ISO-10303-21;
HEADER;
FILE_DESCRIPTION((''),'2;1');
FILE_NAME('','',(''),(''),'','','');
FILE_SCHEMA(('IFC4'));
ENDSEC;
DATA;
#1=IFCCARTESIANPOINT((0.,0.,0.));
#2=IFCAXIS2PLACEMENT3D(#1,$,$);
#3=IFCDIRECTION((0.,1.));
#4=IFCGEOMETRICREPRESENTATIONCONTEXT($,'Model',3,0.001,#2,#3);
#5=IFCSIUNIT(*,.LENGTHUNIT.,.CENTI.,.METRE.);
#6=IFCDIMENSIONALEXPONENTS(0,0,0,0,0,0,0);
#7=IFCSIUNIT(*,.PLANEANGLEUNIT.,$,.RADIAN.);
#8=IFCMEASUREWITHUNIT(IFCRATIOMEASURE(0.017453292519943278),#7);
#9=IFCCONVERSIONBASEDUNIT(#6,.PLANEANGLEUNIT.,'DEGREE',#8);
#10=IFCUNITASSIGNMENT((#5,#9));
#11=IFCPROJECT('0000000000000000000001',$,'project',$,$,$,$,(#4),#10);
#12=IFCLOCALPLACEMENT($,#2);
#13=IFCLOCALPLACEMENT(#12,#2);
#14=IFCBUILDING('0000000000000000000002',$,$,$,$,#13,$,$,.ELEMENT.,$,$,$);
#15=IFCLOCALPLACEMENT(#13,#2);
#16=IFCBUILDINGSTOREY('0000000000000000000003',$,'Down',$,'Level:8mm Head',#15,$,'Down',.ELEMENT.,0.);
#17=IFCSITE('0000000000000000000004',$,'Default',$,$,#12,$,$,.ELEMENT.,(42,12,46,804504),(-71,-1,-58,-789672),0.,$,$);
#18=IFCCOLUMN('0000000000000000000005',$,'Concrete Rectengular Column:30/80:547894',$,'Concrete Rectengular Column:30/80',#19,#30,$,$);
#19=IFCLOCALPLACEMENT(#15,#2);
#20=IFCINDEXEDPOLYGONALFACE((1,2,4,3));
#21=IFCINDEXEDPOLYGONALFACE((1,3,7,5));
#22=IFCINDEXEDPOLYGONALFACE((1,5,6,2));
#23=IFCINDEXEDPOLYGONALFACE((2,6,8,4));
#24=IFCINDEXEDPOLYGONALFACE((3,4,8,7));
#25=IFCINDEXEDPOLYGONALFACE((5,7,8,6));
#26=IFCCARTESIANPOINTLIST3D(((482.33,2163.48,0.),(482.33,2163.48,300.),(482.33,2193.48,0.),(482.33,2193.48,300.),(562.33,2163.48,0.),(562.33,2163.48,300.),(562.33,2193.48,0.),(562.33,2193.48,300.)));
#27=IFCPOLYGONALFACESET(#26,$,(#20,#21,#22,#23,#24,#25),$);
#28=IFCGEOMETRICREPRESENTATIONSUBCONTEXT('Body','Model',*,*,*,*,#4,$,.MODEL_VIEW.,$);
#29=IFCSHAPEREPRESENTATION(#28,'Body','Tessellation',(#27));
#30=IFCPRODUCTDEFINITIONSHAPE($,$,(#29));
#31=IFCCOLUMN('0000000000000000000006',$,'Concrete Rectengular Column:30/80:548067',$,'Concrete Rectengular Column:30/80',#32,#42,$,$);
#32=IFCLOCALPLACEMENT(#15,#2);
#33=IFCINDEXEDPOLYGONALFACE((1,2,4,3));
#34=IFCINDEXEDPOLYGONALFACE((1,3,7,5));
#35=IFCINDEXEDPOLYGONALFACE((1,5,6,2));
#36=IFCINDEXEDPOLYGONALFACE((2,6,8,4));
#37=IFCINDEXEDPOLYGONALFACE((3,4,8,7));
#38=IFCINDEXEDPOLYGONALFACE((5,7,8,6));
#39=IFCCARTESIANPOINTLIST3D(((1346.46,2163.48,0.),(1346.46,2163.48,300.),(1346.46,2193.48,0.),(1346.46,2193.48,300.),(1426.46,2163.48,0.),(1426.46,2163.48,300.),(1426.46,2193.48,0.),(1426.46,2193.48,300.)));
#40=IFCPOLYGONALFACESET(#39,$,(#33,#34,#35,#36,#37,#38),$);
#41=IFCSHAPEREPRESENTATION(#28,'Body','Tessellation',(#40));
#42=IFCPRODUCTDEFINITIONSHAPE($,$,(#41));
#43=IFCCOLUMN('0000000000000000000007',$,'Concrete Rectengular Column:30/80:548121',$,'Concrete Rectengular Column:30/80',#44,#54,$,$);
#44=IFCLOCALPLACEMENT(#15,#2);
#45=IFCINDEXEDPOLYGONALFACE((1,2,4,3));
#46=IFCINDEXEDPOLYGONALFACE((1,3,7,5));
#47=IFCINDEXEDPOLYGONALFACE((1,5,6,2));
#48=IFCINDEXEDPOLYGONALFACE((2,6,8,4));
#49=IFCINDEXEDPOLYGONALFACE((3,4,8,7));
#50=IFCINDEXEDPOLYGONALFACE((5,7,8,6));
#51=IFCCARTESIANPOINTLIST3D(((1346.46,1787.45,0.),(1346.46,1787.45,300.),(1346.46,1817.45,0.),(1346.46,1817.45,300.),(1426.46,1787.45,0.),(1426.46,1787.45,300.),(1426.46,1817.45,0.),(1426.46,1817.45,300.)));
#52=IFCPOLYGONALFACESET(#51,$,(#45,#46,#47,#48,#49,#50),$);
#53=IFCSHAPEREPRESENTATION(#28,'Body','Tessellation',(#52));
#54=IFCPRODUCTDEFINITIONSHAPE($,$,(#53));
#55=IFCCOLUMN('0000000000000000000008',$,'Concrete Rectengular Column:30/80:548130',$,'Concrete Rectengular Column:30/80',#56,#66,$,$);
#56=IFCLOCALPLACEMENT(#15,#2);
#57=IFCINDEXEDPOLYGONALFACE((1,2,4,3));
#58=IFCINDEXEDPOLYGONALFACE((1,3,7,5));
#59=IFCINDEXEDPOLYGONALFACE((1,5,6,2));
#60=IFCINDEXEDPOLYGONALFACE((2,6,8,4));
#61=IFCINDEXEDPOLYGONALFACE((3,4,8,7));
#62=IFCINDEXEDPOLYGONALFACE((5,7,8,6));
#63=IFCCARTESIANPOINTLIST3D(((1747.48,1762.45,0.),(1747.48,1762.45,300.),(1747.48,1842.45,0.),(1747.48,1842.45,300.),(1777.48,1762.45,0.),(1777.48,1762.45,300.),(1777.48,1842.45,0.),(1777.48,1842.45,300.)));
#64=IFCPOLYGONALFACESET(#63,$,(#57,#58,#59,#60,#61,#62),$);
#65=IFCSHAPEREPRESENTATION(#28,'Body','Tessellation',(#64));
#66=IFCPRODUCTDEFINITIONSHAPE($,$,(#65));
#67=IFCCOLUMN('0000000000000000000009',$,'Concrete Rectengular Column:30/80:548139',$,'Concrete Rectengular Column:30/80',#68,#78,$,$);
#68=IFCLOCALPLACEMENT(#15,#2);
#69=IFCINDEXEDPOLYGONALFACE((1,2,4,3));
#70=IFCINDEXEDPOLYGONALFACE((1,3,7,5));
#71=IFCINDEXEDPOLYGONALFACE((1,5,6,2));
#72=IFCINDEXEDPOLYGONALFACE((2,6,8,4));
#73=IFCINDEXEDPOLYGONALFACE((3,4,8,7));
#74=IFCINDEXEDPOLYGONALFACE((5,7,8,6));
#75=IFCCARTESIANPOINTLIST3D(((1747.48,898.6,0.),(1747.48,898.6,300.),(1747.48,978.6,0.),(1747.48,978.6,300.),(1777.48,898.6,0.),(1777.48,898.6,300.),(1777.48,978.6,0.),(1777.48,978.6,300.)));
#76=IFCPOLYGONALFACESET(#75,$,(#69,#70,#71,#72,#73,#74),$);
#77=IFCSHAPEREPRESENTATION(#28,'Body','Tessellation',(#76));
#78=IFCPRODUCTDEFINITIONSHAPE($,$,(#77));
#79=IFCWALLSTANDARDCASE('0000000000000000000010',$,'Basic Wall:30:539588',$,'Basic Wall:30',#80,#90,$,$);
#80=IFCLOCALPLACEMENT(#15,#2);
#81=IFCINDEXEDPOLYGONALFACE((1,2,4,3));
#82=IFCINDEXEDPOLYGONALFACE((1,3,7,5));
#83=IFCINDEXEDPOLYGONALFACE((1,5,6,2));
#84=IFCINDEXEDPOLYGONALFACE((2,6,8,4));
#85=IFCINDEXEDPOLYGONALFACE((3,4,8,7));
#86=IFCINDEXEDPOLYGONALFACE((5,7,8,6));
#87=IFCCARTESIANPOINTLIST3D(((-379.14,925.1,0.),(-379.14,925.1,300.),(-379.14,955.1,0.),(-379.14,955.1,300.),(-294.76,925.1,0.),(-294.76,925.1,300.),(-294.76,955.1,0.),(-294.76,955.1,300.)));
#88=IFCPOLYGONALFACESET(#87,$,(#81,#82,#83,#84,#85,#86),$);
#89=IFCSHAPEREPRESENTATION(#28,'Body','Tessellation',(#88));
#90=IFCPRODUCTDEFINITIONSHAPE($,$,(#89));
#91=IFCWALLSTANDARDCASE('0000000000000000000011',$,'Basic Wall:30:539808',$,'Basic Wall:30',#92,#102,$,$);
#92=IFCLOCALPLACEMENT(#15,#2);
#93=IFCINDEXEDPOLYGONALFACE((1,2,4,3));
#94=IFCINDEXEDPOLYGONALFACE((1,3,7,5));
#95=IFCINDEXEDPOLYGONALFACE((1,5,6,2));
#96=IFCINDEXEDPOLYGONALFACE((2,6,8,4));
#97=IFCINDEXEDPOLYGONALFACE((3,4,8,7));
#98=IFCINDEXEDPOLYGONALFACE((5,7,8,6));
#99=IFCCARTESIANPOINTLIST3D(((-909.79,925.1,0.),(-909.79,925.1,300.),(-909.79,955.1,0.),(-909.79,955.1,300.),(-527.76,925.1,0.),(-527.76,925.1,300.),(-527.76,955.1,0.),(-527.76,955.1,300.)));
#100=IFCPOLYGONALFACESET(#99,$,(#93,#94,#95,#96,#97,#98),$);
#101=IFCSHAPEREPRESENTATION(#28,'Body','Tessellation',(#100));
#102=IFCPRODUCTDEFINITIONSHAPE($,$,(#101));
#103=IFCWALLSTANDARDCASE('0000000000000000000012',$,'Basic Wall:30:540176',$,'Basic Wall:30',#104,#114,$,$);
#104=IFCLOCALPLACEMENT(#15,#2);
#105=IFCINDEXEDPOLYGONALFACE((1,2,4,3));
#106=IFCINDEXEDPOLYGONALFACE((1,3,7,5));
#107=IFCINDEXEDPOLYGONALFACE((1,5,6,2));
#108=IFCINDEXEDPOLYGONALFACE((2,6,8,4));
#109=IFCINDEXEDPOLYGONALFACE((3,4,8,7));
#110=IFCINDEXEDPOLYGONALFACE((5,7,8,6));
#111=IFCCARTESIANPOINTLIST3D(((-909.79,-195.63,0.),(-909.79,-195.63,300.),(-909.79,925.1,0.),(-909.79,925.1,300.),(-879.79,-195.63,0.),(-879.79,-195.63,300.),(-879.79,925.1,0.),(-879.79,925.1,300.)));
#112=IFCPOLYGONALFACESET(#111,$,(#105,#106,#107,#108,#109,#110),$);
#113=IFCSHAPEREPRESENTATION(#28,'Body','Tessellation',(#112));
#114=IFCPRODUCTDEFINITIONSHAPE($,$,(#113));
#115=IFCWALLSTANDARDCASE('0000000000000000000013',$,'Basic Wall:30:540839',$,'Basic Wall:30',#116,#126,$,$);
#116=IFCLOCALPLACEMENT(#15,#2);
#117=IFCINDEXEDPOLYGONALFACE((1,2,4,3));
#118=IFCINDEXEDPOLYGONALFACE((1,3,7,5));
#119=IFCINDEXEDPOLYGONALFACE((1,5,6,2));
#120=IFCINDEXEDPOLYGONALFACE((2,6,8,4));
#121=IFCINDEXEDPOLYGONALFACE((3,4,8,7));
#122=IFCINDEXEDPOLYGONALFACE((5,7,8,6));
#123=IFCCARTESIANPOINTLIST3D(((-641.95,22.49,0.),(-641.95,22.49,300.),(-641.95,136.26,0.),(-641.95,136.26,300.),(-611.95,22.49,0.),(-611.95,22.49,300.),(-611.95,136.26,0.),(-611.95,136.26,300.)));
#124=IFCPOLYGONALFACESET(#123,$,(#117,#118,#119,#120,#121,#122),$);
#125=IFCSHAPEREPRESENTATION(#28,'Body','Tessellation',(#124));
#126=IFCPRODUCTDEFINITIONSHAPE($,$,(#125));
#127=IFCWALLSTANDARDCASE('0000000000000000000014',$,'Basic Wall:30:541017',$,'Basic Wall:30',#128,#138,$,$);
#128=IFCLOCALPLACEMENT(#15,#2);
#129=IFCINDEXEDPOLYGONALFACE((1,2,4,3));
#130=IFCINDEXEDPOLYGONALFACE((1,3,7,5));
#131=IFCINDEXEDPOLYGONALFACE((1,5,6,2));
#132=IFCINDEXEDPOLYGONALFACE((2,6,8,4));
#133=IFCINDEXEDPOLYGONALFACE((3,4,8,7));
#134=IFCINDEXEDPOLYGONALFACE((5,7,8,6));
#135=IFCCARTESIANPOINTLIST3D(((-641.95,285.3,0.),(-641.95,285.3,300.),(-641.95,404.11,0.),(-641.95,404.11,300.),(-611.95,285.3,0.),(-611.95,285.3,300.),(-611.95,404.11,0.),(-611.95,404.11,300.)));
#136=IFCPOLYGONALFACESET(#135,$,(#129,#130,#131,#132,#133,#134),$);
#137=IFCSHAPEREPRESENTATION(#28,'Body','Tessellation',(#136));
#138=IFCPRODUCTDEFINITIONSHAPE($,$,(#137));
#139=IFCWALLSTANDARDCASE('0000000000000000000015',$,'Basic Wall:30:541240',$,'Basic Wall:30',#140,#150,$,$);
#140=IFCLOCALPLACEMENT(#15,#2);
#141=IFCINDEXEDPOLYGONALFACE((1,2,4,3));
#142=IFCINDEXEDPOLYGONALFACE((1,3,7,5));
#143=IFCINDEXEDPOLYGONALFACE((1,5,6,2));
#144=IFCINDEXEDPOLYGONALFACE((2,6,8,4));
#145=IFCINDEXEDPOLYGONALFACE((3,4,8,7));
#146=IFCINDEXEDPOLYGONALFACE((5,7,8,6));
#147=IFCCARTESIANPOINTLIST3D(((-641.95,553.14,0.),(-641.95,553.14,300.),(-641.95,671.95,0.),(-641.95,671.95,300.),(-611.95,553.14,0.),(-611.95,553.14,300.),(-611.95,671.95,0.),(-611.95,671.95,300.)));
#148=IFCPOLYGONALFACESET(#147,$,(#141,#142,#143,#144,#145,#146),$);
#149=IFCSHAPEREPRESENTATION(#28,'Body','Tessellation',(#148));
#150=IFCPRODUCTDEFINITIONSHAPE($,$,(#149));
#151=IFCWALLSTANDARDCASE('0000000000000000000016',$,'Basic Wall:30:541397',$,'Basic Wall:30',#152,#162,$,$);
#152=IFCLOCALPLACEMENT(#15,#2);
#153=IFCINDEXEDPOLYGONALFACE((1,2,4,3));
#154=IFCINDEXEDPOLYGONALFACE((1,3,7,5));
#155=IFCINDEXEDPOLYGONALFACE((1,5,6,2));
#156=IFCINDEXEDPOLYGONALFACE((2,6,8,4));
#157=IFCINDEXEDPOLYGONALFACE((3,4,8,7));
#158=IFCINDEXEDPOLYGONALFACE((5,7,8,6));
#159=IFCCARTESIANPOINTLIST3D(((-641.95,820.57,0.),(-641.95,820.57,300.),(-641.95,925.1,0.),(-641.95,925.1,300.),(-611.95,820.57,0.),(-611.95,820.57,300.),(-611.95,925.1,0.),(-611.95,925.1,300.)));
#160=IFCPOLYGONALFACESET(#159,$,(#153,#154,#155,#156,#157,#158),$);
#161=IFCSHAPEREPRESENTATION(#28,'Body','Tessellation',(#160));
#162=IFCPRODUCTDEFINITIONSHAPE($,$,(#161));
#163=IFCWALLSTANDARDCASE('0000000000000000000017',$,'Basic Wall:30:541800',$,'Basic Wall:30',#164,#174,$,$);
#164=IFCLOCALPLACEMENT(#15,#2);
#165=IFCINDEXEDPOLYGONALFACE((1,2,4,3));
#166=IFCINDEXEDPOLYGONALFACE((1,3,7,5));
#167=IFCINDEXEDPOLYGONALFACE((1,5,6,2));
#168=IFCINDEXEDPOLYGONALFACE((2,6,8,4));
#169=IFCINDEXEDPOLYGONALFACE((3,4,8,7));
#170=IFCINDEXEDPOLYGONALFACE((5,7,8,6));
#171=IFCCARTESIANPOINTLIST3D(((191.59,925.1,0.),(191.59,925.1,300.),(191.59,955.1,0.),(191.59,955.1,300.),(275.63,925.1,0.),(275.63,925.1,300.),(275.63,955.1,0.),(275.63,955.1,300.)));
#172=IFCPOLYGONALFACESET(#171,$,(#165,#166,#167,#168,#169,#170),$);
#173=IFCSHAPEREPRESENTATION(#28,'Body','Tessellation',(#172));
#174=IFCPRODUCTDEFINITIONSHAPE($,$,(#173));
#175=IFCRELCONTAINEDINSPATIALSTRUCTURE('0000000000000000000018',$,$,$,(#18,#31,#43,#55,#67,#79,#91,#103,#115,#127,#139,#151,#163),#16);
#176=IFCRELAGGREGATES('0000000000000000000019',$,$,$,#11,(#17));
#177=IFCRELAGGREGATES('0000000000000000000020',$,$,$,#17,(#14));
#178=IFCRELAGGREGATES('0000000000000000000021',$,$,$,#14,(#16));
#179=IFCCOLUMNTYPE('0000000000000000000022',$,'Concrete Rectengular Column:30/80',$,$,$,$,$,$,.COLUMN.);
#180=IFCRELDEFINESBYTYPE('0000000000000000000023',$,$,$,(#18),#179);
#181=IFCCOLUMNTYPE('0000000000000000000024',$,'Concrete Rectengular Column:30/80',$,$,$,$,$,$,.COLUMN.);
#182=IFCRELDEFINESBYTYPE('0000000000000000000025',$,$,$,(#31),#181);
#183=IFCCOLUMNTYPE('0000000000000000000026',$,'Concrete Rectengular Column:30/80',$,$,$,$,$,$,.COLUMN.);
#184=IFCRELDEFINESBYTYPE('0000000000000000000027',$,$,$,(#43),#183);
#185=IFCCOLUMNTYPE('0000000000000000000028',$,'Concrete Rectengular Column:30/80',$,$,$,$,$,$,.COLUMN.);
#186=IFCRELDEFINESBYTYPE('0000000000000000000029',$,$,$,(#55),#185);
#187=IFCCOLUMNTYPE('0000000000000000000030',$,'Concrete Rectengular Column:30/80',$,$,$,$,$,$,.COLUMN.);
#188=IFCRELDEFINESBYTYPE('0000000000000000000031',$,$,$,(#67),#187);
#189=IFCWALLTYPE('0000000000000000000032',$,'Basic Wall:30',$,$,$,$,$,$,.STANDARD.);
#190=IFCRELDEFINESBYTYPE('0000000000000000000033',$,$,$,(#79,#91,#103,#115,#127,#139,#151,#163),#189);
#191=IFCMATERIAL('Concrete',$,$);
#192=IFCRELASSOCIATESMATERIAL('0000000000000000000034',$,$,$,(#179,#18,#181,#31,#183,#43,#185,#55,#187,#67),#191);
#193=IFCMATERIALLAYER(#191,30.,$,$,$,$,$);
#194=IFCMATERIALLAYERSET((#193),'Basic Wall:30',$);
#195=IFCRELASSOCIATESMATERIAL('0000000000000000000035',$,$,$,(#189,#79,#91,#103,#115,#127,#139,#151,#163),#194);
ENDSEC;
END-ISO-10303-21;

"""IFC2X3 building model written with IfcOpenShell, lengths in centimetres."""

from ifc_helpers import new_model, entity, si_unit, converted_unit, direction, frame, frame_2d, origin, origin_2d_with_axis, place, context, subcontext, project, spatial, rectangle, extrude, source, transform, mapped, material, layer, layer_set, layer_usage, type_object, type_shapes, element, save


model = new_model("IFC2X3")

# Units and contexts
model_context = context("Model", 3, precision=0.001, world=origin(), true_north=direction((0.0, 1.0)))
body_context = subcontext(model_context, "Body", "Model", "MODEL_VIEW")
ifc_project = project(units=[si_unit("LENGTHUNIT", "METRE", prefix="CENTI"), converted_unit("PLANEANGLEUNIT", "DEGREE", entity("IfcRatioMeasure", 0.017453292519943278), si_unit("PLANEANGLEUNIT", "RADIAN"), dimensions=[0, 0, 0, 0, 0, 0, 0])], contexts=[model_context])

# Site, building, storey
site_placement = place(None, origin())
site = spatial("IfcSite", under=ifc_project, at=site_placement, Name="Default", CompositionType="ELEMENT", RefLatitude=(42, 12, 46, 804504), RefLongitude=(-71, -1, -58, -789672), RefElevation=0.0)
building_placement = place(site_placement, origin())
building = spatial("IfcBuilding", under=site, at=building_placement, CompositionType="ELEMENT")
storey_placement = place(building_placement, origin())
storey = spatial("IfcBuildingStorey", under=building, at=storey_placement, Name="Down", ObjectType="Level:8mm Head", LongName="Down", CompositionType="ELEMENT", Elevation=0.0)

# Columns
ifc_material = material(Name="Concrete")
column_type_1 = type_object("IfcColumnType", Name="Concrete Rectengular Column:30/80", PredefinedType="COLUMN", material=ifc_material)
shared_shape_1 = source(origin(), body_context, "Body", "SweptSolid", [
    extrude(rectangle(XDim=30.0, YDim=80.0, at=origin_2d_with_axis()), frame((522.33, 2178.48, 0.0), z_axis=(0.0, 0.0, 1.0), x_axis=(0.0, -1.0, 0.0)), (0.0, 0.0, 1.0), 300.0),
])
type_shapes(column_type_1, [shared_shape_1])
column_1_placement = place(storey_placement, origin())
element("IfcColumn", 1, at=column_1_placement, inside=storey, type_object=column_type_1, material=ifc_material, Name="Concrete Rectengular Column:30/80:547894", ObjectType="Concrete Rectengular Column:30/80", context=body_context, shape_type="MappedRepresentation", body=[
    mapped(shared_shape_1, transform((0.0, 0.0, 0.0), scale=1.0)),
])
column_type_2 = type_object("IfcColumnType", Name="Concrete Rectengular Column:30/80", PredefinedType="COLUMN", material=ifc_material)
shared_shape_2 = source(origin(), body_context, "Body", "SweptSolid", [
    extrude(rectangle(XDim=30.0, YDim=80.0, at=origin_2d_with_axis()), frame((1386.46, 2178.48, 0.0), z_axis=(0.0, 0.0, 1.0), x_axis=(0.0, -1.0, 0.0)), (0.0, 0.0, 1.0), 300.0),
])
type_shapes(column_type_2, [shared_shape_2])
column_2_placement = place(storey_placement, origin())
element("IfcColumn", 2, at=column_2_placement, inside=storey, type_object=column_type_2, material=ifc_material, Name="Concrete Rectengular Column:30/80:548067", ObjectType="Concrete Rectengular Column:30/80", context=body_context, shape_type="MappedRepresentation", body=[
    mapped(shared_shape_2, transform((0.0, 0.0, 0.0), scale=1.0)),
])
column_type_3 = type_object("IfcColumnType", Name="Concrete Rectengular Column:30/80", PredefinedType="COLUMN", material=ifc_material)
shared_shape_3 = source(origin(), body_context, "Body", "SweptSolid", [
    extrude(rectangle(XDim=30.0, YDim=80.0, at=origin_2d_with_axis()), frame((1386.46, 1802.45, 0.0), z_axis=(0.0, 0.0, 1.0), x_axis=(0.0, -1.0, 0.0)), (0.0, 0.0, 1.0), 300.0),
])
type_shapes(column_type_3, [shared_shape_3])
column_3_placement = place(storey_placement, origin())
element("IfcColumn", 3, at=column_3_placement, inside=storey, type_object=column_type_3, material=ifc_material, Name="Concrete Rectengular Column:30/80:548121", ObjectType="Concrete Rectengular Column:30/80", context=body_context, shape_type="MappedRepresentation", body=[
    mapped(shared_shape_3, transform((0.0, 0.0, 0.0), scale=1.0)),
])
column_type_4 = type_object("IfcColumnType", Name="Concrete Rectengular Column:30/80", PredefinedType="COLUMN", material=ifc_material)
shared_shape_4 = source(origin(), body_context, "Body", "SweptSolid", [
    extrude(rectangle(XDim=80.0, YDim=30.0, at=origin_2d_with_axis()), frame((1762.48, 1802.45, 0.0), z_axis=(0.0, 0.0, 1.0), x_axis=(0.0, -1.0, 0.0)), (0.0, 0.0, 1.0), 300.0),
])
type_shapes(column_type_4, [shared_shape_4])
column_4_placement = place(storey_placement, origin())
element("IfcColumn", 4, at=column_4_placement, inside=storey, type_object=column_type_4, material=ifc_material, Name="Concrete Rectengular Column:30/80:548130", ObjectType="Concrete Rectengular Column:30/80", context=body_context, shape_type="MappedRepresentation", body=[
    mapped(shared_shape_4, transform((0.0, 0.0, 0.0), scale=1.0)),
])
column_type_5 = type_object("IfcColumnType", Name="Concrete Rectengular Column:30/80", PredefinedType="COLUMN", material=ifc_material)
shared_shape_5 = source(origin(), body_context, "Body", "SweptSolid", [
    extrude(rectangle(XDim=80.0, YDim=30.0, at=frame_2d((0.0, 0.0), x_axis=(1.0, 0.0))), frame((1762.48, 938.6, 0.0), z_axis=(0.0, 0.0, 1.0), x_axis=(0.0, -1.0, 0.0)), (0.0, 0.0, 1.0), 300.0),
])
type_shapes(column_type_5, [shared_shape_5])
column_5_placement = place(storey_placement, origin())
element("IfcColumn", 5, at=column_5_placement, inside=storey, type_object=column_type_5, material=ifc_material, Name="Concrete Rectengular Column:30/80:548139", ObjectType="Concrete Rectengular Column:30/80", context=body_context, shape_type="MappedRepresentation", body=[
    mapped(shared_shape_5, transform((0.0, 0.0, 0.0), scale=1.0)),
])

# Walls
ifc_layer_1 = layer(ifc_material, 30.0)
ifc_layer_set_1 = layer_set([ifc_layer_1], Name="Basic Wall:30")
ifc_layer_usage_1 = layer_usage(ifc_layer_set_1, "AXIS2", "NEGATIVE", 15.0)
wall_type_1 = type_object("IfcWallType", Name="Basic Wall:30", PredefinedType="STANDARD", material=ifc_layer_set_1)
wall_1_placement = place(storey_placement, frame((-294.76, 940.1, 0.0), z_axis=(0.0, 0.0, 1.0), x_axis=(-1.0, 0.0, 0.0)))
element("IfcWallStandardCase", 6, at=wall_1_placement, inside=storey, type_object=wall_type_1, material=ifc_layer_usage_1, Name="Basic Wall:30:539588", ObjectType="Basic Wall:30", context=body_context, shape_type="SweptSolid", body=[
    extrude(rectangle(XDim=84.38, YDim=30.0, at=frame_2d((42.19, 0.0), x_axis=(-1.0, 0.0))), origin(), (0.0, 0.0, 1.0), 300.0),
])
ifc_layer_usage_2 = layer_usage(ifc_layer_set_1, "AXIS2", "NEGATIVE", 15.0)
wall_2_placement = place(storey_placement, frame((-527.76, 940.1, 0.0), z_axis=(0.0, 0.0, 1.0), x_axis=(-1.0, 0.0, 0.0)))
element("IfcWallStandardCase", 7, at=wall_2_placement, inside=storey, type_object=wall_type_1, material=ifc_layer_usage_2, Name="Basic Wall:30:539808", ObjectType="Basic Wall:30", context=body_context, shape_type="SweptSolid", body=[
    extrude(rectangle(XDim=382.04, YDim=30.0, at=frame_2d((191.02, 0.0), x_axis=(-1.0, 0.0))), origin(), (0.0, 0.0, 1.0), 300.0),
])
ifc_layer_usage_3 = layer_usage(ifc_layer_set_1, "AXIS2", "POSITIVE", -15.0)
wall_3_placement = place(storey_placement, frame((-894.79, 925.1, 0.0), z_axis=(0.0, 0.0, 1.0), x_axis=(0.0, -1.0, 0.0)))
element("IfcWallStandardCase", 8, at=wall_3_placement, inside=storey, type_object=wall_type_1, material=ifc_layer_usage_3, Name="Basic Wall:30:540176", ObjectType="Basic Wall:30", context=body_context, shape_type="SweptSolid", body=[
    extrude(rectangle(XDim=1120.73, YDim=30.0, at=frame_2d((560.36, 0.0), x_axis=(-1.0, 0.0))), origin(), (0.0, 0.0, 1.0), 300.0),
])
ifc_layer_usage_4 = layer_usage(ifc_layer_set_1, "AXIS2", "NEGATIVE", 15.0)
wall_4_placement = place(storey_placement, frame((-626.95, 22.49, 0.0), z_axis=(0.0, 0.0, 1.0), x_axis=(0.0, 1.0, 0.0)))
element("IfcWallStandardCase", 9, at=wall_4_placement, inside=storey, type_object=wall_type_1, material=ifc_layer_usage_4, Name="Basic Wall:30:540839", ObjectType="Basic Wall:30", context=body_context, shape_type="SweptSolid", body=[
    extrude(rectangle(XDim=113.77, YDim=30.0, at=frame_2d((56.89, 0.0), x_axis=(-1.0, 0.0))), origin(), (0.0, 0.0, 1.0), 300.0),
])
ifc_layer_usage_5 = layer_usage(ifc_layer_set_1, "AXIS2", "NEGATIVE", 15.0)
wall_5_placement = place(storey_placement, frame((-626.95, 285.3, 0.0), z_axis=(0.0, 0.0, 1.0), x_axis=(0.0, 1.0, 0.0)))
element("IfcWallStandardCase", 10, at=wall_5_placement, inside=storey, type_object=wall_type_1, material=ifc_layer_usage_5, Name="Basic Wall:30:541017", ObjectType="Basic Wall:30", context=body_context, shape_type="SweptSolid", body=[
    extrude(rectangle(XDim=118.81, YDim=30.0, at=frame_2d((59.4, 0.0), x_axis=(-1.0, 0.0))), origin(), (0.0, 0.0, 1.0), 300.0),
])
ifc_layer_usage_6 = layer_usage(ifc_layer_set_1, "AXIS2", "NEGATIVE", 15.0)
wall_6_placement = place(storey_placement, frame((-626.95, 553.14, 0.0), z_axis=(0.0, 0.0, 1.0), x_axis=(0.0, 1.0, 0.0)))
element("IfcWallStandardCase", 11, at=wall_6_placement, inside=storey, type_object=wall_type_1, material=ifc_layer_usage_6, Name="Basic Wall:30:541240", ObjectType="Basic Wall:30", context=body_context, shape_type="SweptSolid", body=[
    extrude(rectangle(XDim=118.81, YDim=30.0, at=frame_2d((59.4, 0.0), x_axis=(-1.0, 0.0))), origin(), (0.0, 0.0, 1.0), 300.0),
])
ifc_layer_usage_7 = layer_usage(ifc_layer_set_1, "AXIS2", "NEGATIVE", 15.0)
wall_7_placement = place(storey_placement, frame((-626.95, 820.57, 0.0), z_axis=(0.0, 0.0, 1.0), x_axis=(0.0, 1.0, 0.0)))
element("IfcWallStandardCase", 12, at=wall_7_placement, inside=storey, type_object=wall_type_1, material=ifc_layer_usage_7, Name="Basic Wall:30:541397", ObjectType="Basic Wall:30", context=body_context, shape_type="SweptSolid", body=[
    extrude(rectangle(XDim=104.54, YDim=30.0, at=frame_2d((52.27, 0.0), x_axis=(-1.0, 0.0))), origin(), (0.0, 0.0, 1.0), 300.0),
])
ifc_layer_usage_8 = layer_usage(ifc_layer_set_1, "AXIS2", "POSITIVE", -15.0)
wall_8_placement = place(storey_placement, frame((191.59, 940.1, 0.0)))
element("IfcWallStandardCase", 13, at=wall_8_placement, inside=storey, type_object=wall_type_1, material=ifc_layer_usage_8, Name="Basic Wall:30:541800", ObjectType="Basic Wall:30", context=body_context, shape_type="SweptSolid", body=[
    extrude(rectangle(XDim=84.04, YDim=30.0, at=frame_2d((42.02, 0.0), x_axis=(-1.0, 0.0))), origin(), (0.0, 0.0, 1.0), 300.0),
])

save(model, "model.ifc")
